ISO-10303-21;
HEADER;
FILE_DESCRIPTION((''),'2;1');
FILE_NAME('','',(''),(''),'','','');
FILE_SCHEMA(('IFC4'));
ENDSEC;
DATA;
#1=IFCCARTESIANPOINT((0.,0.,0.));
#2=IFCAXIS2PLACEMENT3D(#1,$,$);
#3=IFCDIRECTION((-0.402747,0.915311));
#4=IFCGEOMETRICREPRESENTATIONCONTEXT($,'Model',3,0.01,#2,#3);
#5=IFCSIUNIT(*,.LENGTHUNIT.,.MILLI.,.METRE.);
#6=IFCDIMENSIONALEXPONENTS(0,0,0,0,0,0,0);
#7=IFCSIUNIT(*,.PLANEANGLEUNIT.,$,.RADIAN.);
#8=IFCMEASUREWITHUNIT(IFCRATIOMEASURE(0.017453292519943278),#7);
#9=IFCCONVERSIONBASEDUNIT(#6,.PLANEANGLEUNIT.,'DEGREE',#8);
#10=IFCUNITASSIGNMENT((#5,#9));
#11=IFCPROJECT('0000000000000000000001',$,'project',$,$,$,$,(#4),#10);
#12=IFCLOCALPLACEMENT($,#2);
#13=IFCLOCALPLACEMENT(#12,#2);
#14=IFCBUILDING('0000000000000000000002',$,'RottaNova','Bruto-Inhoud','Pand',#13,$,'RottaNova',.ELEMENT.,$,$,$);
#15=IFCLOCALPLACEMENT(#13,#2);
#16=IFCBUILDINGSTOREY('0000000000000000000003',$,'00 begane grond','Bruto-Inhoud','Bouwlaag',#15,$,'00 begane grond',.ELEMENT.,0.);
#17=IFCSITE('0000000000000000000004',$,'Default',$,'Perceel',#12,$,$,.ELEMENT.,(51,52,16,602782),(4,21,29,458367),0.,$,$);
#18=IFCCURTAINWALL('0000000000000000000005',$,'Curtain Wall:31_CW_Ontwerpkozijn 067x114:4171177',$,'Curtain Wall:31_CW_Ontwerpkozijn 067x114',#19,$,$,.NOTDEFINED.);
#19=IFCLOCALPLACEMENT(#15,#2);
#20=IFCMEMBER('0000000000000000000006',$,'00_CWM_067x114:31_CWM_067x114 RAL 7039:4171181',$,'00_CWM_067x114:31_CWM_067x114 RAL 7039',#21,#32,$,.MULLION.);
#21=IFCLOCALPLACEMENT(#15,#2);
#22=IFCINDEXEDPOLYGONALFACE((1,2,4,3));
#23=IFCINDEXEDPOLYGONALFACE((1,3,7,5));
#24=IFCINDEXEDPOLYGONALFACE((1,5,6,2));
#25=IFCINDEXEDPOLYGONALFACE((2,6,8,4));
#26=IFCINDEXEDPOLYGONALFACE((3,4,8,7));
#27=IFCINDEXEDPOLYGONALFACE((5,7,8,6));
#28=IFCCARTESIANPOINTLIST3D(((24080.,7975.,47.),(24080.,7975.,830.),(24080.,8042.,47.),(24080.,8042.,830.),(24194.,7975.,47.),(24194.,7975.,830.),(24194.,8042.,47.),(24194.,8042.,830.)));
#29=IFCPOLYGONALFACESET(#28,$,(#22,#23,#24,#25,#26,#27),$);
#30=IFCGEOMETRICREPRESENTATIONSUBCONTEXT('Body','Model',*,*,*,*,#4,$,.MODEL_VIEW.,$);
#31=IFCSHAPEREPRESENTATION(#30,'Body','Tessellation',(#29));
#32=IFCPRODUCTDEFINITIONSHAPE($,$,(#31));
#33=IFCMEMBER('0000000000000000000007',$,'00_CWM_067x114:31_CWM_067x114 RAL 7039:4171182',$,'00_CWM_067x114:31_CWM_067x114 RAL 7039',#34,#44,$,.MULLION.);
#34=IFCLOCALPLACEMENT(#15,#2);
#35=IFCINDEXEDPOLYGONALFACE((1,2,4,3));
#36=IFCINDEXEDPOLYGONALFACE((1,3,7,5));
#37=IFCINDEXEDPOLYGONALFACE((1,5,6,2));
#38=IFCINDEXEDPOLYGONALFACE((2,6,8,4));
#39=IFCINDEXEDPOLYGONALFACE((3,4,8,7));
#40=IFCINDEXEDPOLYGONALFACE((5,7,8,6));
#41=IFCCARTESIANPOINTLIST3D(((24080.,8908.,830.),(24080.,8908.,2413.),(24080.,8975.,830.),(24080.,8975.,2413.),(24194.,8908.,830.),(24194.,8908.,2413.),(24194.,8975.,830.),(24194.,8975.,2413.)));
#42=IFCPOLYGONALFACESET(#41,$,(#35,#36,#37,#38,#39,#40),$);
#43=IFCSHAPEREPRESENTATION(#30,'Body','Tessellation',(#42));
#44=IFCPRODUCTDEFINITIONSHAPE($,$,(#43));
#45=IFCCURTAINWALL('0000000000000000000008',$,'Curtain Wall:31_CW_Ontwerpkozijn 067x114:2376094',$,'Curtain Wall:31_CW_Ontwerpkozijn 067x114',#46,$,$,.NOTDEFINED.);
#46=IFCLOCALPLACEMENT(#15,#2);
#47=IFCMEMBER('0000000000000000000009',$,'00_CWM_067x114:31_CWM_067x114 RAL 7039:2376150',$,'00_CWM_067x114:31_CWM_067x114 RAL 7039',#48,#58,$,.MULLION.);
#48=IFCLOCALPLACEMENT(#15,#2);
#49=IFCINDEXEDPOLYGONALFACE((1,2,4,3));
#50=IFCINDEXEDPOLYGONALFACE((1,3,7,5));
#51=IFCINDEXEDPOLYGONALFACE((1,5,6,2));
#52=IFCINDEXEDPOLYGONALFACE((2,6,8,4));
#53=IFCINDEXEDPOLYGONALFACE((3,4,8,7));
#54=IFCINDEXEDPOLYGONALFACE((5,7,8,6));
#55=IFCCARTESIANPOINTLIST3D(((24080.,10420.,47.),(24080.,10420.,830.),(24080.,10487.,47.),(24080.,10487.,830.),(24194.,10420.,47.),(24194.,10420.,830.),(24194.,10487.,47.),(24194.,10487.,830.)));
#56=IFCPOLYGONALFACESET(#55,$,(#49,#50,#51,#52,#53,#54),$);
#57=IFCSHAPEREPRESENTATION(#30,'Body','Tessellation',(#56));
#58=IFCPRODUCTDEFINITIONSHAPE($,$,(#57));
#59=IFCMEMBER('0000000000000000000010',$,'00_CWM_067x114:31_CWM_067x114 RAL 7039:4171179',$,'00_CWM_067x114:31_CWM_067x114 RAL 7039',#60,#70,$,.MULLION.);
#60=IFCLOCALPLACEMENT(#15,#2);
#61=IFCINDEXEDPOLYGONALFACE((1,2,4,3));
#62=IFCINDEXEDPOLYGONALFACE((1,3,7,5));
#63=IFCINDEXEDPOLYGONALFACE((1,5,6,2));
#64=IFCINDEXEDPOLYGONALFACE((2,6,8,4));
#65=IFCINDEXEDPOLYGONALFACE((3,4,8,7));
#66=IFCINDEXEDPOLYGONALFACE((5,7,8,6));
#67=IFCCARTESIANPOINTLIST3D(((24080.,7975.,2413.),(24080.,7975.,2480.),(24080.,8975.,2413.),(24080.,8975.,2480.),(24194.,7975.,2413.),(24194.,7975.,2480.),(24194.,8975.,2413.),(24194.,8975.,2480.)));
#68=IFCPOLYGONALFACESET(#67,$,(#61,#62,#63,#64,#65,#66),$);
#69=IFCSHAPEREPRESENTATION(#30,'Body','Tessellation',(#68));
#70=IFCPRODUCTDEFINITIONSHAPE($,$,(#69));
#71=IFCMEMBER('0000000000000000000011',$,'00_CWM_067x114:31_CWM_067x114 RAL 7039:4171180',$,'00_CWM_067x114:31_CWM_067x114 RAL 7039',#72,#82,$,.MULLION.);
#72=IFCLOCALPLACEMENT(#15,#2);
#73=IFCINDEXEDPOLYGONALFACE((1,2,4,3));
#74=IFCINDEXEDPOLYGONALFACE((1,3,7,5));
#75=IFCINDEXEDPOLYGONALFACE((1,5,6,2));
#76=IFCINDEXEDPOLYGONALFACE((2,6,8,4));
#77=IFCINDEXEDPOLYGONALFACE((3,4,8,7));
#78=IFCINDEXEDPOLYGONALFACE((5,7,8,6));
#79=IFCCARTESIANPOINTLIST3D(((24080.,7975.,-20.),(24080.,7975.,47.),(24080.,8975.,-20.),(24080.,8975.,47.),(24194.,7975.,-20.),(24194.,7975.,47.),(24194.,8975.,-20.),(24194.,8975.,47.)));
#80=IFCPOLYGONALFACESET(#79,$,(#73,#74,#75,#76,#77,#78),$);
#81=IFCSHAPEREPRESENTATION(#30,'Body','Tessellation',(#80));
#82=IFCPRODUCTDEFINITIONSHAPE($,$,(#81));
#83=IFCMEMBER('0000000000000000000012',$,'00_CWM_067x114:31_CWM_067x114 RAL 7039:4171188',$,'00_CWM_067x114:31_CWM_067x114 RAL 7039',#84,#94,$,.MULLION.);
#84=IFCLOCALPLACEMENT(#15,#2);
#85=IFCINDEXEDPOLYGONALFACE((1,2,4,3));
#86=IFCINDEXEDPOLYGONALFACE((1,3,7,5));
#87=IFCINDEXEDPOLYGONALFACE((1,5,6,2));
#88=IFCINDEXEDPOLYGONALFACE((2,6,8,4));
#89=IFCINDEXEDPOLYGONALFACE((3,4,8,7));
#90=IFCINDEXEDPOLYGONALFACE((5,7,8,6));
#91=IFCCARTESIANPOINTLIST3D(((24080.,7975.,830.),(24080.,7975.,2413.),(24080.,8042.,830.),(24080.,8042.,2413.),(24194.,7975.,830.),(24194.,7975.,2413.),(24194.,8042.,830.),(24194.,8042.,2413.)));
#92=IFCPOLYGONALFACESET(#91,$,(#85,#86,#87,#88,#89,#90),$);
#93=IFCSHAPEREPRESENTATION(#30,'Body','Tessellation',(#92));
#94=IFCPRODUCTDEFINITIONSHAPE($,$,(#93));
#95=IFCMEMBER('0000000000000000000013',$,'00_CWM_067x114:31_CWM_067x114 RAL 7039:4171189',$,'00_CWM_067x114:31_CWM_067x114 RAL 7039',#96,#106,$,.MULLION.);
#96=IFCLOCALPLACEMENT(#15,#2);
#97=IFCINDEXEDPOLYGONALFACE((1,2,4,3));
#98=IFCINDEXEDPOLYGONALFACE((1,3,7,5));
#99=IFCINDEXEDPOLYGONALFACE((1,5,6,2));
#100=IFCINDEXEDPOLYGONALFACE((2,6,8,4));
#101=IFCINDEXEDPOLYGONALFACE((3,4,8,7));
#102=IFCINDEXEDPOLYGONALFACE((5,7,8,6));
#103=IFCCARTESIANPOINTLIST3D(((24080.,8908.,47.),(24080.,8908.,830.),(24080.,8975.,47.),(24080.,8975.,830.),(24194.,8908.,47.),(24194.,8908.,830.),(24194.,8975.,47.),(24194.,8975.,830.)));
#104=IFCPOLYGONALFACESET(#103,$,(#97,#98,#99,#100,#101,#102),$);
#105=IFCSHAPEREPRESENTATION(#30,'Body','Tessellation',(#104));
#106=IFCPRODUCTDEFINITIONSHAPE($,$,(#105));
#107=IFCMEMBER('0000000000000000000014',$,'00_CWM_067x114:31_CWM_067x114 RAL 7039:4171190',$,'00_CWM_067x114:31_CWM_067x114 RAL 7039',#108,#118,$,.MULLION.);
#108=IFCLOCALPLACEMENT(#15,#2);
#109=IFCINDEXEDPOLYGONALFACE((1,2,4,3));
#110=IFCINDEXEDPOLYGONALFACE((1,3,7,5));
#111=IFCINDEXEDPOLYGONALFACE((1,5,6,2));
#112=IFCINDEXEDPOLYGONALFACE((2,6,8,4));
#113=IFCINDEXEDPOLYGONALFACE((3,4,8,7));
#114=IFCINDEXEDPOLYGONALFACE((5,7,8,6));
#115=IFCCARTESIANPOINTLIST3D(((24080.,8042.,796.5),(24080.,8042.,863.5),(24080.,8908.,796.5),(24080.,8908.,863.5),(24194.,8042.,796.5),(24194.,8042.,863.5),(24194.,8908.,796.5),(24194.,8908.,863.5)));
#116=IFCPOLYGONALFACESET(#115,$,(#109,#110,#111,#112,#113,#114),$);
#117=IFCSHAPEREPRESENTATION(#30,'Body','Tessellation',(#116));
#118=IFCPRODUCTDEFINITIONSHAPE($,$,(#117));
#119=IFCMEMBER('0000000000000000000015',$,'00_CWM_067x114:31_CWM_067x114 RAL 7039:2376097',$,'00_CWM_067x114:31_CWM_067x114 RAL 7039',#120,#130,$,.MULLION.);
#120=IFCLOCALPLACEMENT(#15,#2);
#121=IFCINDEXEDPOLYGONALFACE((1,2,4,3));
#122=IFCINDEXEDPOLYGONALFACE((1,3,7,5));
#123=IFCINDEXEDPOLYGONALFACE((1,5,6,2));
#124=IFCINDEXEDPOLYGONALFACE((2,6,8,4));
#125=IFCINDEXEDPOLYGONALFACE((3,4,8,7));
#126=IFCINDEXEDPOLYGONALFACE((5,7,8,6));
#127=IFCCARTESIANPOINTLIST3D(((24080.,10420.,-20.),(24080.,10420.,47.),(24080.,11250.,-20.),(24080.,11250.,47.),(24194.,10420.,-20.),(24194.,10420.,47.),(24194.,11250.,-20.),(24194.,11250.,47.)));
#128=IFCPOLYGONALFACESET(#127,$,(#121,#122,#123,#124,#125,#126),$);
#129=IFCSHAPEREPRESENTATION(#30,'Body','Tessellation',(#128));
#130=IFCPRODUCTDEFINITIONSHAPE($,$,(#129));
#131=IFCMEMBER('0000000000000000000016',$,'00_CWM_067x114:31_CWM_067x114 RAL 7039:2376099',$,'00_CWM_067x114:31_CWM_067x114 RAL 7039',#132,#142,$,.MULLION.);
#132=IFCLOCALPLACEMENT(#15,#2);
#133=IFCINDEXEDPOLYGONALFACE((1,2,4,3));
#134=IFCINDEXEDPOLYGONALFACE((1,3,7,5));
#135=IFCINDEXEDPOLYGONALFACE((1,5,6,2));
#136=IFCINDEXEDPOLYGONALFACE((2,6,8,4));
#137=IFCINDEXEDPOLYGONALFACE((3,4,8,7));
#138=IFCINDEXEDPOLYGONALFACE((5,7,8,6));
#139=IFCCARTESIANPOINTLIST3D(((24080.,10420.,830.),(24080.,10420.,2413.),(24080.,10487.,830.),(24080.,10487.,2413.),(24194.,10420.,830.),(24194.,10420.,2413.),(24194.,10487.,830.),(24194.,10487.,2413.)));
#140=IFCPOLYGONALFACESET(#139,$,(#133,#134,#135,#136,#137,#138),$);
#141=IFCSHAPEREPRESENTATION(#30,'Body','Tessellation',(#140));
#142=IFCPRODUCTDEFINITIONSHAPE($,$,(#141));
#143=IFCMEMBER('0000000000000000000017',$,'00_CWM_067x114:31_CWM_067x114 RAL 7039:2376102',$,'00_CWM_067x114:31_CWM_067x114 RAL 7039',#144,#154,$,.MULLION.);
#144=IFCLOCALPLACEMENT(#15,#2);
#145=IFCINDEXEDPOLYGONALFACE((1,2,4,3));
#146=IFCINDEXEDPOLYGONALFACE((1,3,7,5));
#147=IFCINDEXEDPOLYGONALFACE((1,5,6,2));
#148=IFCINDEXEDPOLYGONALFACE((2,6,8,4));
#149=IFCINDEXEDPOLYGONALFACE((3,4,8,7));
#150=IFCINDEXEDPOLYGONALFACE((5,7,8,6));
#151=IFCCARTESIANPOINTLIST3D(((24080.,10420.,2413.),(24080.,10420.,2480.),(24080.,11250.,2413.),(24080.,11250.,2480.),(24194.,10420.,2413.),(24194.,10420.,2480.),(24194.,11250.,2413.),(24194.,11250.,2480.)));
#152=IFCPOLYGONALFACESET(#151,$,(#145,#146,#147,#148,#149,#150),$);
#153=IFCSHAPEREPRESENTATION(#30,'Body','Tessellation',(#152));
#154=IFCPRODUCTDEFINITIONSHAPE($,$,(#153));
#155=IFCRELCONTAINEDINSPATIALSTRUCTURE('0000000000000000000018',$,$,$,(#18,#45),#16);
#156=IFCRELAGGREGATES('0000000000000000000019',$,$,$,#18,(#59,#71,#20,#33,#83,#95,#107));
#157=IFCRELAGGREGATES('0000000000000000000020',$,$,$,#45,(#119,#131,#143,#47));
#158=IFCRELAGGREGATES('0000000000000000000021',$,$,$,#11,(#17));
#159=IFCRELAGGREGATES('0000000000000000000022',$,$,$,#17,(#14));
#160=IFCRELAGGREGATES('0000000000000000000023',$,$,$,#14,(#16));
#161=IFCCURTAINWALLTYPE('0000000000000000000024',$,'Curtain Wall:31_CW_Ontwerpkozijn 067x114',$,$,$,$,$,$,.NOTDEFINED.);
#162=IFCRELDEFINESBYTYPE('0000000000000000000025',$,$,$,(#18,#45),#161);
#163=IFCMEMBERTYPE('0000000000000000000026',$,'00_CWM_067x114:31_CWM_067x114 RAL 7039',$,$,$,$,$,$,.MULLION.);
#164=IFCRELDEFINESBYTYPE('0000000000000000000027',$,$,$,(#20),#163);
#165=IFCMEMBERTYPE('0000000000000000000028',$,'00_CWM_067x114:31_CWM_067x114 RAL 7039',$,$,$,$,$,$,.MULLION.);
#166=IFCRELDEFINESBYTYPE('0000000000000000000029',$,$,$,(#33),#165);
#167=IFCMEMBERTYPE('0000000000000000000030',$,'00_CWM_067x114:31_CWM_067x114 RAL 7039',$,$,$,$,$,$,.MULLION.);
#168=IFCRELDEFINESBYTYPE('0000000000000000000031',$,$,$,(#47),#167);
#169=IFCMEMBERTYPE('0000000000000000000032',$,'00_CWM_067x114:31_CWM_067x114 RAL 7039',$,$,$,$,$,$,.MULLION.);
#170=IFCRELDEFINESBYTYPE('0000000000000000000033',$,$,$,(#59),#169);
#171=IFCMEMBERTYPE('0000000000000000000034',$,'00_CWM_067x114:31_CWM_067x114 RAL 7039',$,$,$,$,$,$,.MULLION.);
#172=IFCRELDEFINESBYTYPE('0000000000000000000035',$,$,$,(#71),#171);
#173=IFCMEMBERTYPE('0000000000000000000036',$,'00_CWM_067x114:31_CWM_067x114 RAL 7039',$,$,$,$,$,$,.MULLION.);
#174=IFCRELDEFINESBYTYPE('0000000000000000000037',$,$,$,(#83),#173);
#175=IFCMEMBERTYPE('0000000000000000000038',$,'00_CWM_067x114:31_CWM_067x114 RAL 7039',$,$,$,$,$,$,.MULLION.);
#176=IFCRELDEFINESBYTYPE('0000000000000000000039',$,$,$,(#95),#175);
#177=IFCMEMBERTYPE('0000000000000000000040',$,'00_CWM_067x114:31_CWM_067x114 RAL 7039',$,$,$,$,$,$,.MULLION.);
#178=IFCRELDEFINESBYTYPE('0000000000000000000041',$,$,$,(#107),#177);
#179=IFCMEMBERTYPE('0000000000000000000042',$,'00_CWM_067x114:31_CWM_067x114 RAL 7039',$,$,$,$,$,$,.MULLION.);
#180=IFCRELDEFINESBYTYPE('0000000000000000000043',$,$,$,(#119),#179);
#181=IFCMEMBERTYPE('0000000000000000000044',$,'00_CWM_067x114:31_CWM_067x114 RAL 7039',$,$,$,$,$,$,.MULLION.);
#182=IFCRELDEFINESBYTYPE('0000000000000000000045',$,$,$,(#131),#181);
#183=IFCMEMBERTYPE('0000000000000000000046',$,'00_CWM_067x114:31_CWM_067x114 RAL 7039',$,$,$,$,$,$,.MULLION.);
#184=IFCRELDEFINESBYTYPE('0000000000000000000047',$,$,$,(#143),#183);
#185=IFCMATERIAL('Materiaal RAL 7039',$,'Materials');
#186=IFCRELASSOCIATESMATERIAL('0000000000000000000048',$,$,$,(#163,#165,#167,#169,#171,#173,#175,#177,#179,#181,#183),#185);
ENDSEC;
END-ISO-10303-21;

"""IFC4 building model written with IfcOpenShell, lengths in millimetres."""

from ifc_helpers import new_model, entity, si_unit, converted_unit, direction, frame, frame_2d, origin, origin_2d_with_axis, place, context, subcontext, project, spatial, rectangle, extrude, source, transform, mapped, material, material_profile, profile_set, type_object, type_shapes, element, aggregate, save


model = new_model("IFC4")

# Units and contexts
model_context = context("Model", 3, precision=0.01, world=origin(), true_north=direction((-0.402747, 0.915311)))
body_context = subcontext(model_context, "Body", "Model", "MODEL_VIEW")
ifc_project = project(units=[si_unit("LENGTHUNIT", "METRE", prefix="MILLI"), converted_unit("PLANEANGLEUNIT", "DEGREE", entity("IfcRatioMeasure", 0.017453292519943278), si_unit("PLANEANGLEUNIT", "RADIAN"), dimensions=[0, 0, 0, 0, 0, 0, 0])], contexts=[model_context])

# Site, building, storey
site_placement = place(None, origin())
site = spatial("IfcSite", under=ifc_project, at=site_placement, Name="Default", ObjectType="Perceel", CompositionType="ELEMENT", RefLatitude=(51, 52, 16, 602782), RefLongitude=(4, 21, 29, 458367), RefElevation=0.0)
building_placement = place(site_placement, origin())
building = spatial("IfcBuilding", under=site, at=building_placement, Name="RottaNova", Description="Bruto-Inhoud", ObjectType="Pand", LongName="RottaNova", CompositionType="ELEMENT")
storey_placement = place(building_placement, origin())
storey = spatial("IfcBuildingStorey", under=building, at=storey_placement, Name="00 begane grond", Description="Bruto-Inhoud", ObjectType="Bouwlaag", LongName="00 begane grond", CompositionType="ELEMENT", Elevation=0.0)

# Curtain wall, members
curtain_wall_type = type_object("IfcCurtainWallType", Name="Curtain Wall:31_CW_Ontwerpkozijn 067x114", PredefinedType="NOTDEFINED")
curtain_wall_1_placement = place(storey_placement, origin())
curtain_wall_1 = element("IfcCurtainWall", 1, at=curtain_wall_1_placement, inside=storey, type_object=curtain_wall_type, Name="Curtain Wall:31_CW_Ontwerpkozijn 067x114:4171177", ObjectType="Curtain Wall:31_CW_Ontwerpkozijn 067x114", PredefinedType="NOTDEFINED")
ifc_material_1 = material(Name="Materiaal RAL 7039", Category="Materials")
ifc_material_profile = material_profile(ifc_material_1, rectangle(XDim=114.0, YDim=67.0, at=origin_2d_with_axis()), Name="31_CWM_067x114 RAL 7039")
ifc_profile_set = profile_set([ifc_material_profile], Name="31_CWM_067x114 RAL 7039")
member_type_1 = type_object("IfcMemberType", Name="00_CWM_067x114:31_CWM_067x114 RAL 7039", PredefinedType="MULLION", material=ifc_profile_set)
shared_shape_1 = source(origin(), body_context, "Body", "SweptSolid", [
    extrude(rectangle(XDim=114.0, YDim=67.0, at=frame_2d((0.0, 0.0), x_axis=(1.0, 0.0))), frame((-33.5, -57.0, -783.0), z_axis=(0.0, 0.0, 1.0), x_axis=(0.0, -1.0, 0.0)), (0.0, 0.0, 1.0), 783.0),
])
type_shapes(member_type_1, [shared_shape_1])
member_1_placement = place(curtain_wall_1_placement, frame((24080.0, 7975.0, 47.0), z_axis=(0.0, 0.0, -1.0), x_axis=(0.0, -1.0, 0.0)))
member_1 = element("IfcMember", 2, at=member_1_placement, type_object=member_type_1, Name="00_CWM_067x114:31_CWM_067x114 RAL 7039:4171181", ObjectType="00_CWM_067x114:31_CWM_067x114 RAL 7039", PredefinedType="MULLION", context=body_context, shape_type="MappedRepresentation", body=[
    mapped(shared_shape_1, transform((0.0, 0.0, 0.0), scale=1.0)),
])
member_type_2 = type_object("IfcMemberType", Name="00_CWM_067x114:31_CWM_067x114 RAL 7039", PredefinedType="MULLION", material=ifc_profile_set)
shared_shape_2 = source(origin(), body_context, "Body", "SweptSolid", [
    extrude(rectangle(XDim=114.0, YDim=67.0, at=frame_2d((0.0, 0.0), x_axis=(1.0, 0.0))), frame((-33.5, -57.0, -1583.0), z_axis=(0.0, 0.0, 1.0), x_axis=(0.0, -1.0, 0.0)), (0.0, 0.0, 1.0), 1583.0),
])
type_shapes(member_type_2, [shared_shape_2])
member_2_placement = place(curtain_wall_1_placement, frame((24080.0, 8975.0, 2413.0), z_axis=(0.0, 0.0, 1.0), x_axis=(0.0, 1.0, 0.0)))
member_2 = element("IfcMember", 3, at=member_2_placement, type_object=member_type_2, Name="00_CWM_067x114:31_CWM_067x114 RAL 7039:4171182", ObjectType="00_CWM_067x114:31_CWM_067x114 RAL 7039", PredefinedType="MULLION", context=body_context, shape_type="MappedRepresentation", body=[
    mapped(shared_shape_2, transform((0.0, 0.0, 0.0), scale=1.0)),
])

# Curtain wall, member
curtain_wall_2_placement = place(storey_placement, origin())
curtain_wall_2 = element("IfcCurtainWall", 4, at=curtain_wall_2_placement, inside=storey, type_object=curtain_wall_type, Name="Curtain Wall:31_CW_Ontwerpkozijn 067x114:2376094", ObjectType="Curtain Wall:31_CW_Ontwerpkozijn 067x114", PredefinedType="NOTDEFINED")
member_type_3 = type_object("IfcMemberType", Name="00_CWM_067x114:31_CWM_067x114 RAL 7039", PredefinedType="MULLION", material=ifc_profile_set)
shared_shape_3 = source(origin(), body_context, "Body", "SweptSolid", [
    extrude(rectangle(XDim=114.0, YDim=67.0, at=origin_2d_with_axis()), frame((-33.5, 57.0, -783.0), z_axis=(0.0, 0.0, 1.0), x_axis=(0.0, -1.0, 0.0)), (0.0, 0.0, 1.0), 783.0),
])
type_shapes(member_type_3, [shared_shape_3])
member_3_placement = place(curtain_wall_2_placement, frame((24080.0, 10420.0, 830.0), z_axis=(0.0, 0.0, 1.0), x_axis=(0.0, -1.0, 0.0)))
member_3 = element("IfcMember", 5, at=member_3_placement, type_object=member_type_3, Name="00_CWM_067x114:31_CWM_067x114 RAL 7039:2376150", ObjectType="00_CWM_067x114:31_CWM_067x114 RAL 7039", PredefinedType="MULLION", context=body_context, shape_type="MappedRepresentation", body=[
    mapped(shared_shape_3, transform((0.0, 0.0, 0.0), scale=1.0)),
])

# Members
member_type_4 = type_object("IfcMemberType", Name="00_CWM_067x114:31_CWM_067x114 RAL 7039", PredefinedType="MULLION", material=ifc_profile_set)
shared_shape_4 = source(origin(), body_context, "Body", "SweptSolid", [
    extrude(rectangle(XDim=114.0, YDim=67.0, at=frame_2d((0.0, 0.0), x_axis=(1.0, 0.0))), frame((-33.5, -57.0, -1000.0), z_axis=(0.0, 0.0, 1.0), x_axis=(0.0, -1.0, 0.0)), (0.0, 0.0, 1.0), 1000.0),
])
type_shapes(member_type_4, [shared_shape_4])
member_4_placement = place(curtain_wall_1_placement, frame((24080.0, 7975.0, 2480.0), z_axis=(0.0, -1.0, 0.0), x_axis=(0.0, 0.0, 1.0)))
member_4 = element("IfcMember", 6, at=member_4_placement, type_object=member_type_4, Name="00_CWM_067x114:31_CWM_067x114 RAL 7039:4171179", ObjectType="00_CWM_067x114:31_CWM_067x114 RAL 7039", PredefinedType="MULLION", context=body_context, shape_type="MappedRepresentation", body=[
    mapped(shared_shape_4, transform((0.0, 0.0, 0.0), scale=1.0)),
])
member_type_5 = type_object("IfcMemberType", Name="00_CWM_067x114:31_CWM_067x114 RAL 7039", PredefinedType="MULLION", material=ifc_profile_set)
shared_shape_5 = source(origin(), body_context, "Body", "SweptSolid", [
    extrude(rectangle(XDim=114.0, YDim=67.0, at=frame_2d((0.0, 0.0), x_axis=(1.0, 0.0))), frame((-33.5, -57.0, -1000.0), z_axis=(0.0, 0.0, 1.0), x_axis=(0.0, -1.0, 0.0)), (0.0, 0.0, 1.0), 1000.0),
])
type_shapes(member_type_5, [shared_shape_5])
member_5_placement = place(curtain_wall_1_placement, frame((24080.0, 8975.0, -20.0), z_axis=(0.0, 1.0, 0.0), x_axis=(0.0, 0.0, -1.0)))
member_5 = element("IfcMember", 7, at=member_5_placement, type_object=member_type_5, Name="00_CWM_067x114:31_CWM_067x114 RAL 7039:4171180", ObjectType="00_CWM_067x114:31_CWM_067x114 RAL 7039", PredefinedType="MULLION", context=body_context, shape_type="MappedRepresentation", body=[
    mapped(shared_shape_5, transform((0.0, 0.0, 0.0), scale=1.0)),
])
member_type_6 = type_object("IfcMemberType", Name="00_CWM_067x114:31_CWM_067x114 RAL 7039", PredefinedType="MULLION", material=ifc_profile_set)
shared_shape_6 = source(origin(), body_context, "Body", "SweptSolid", [
    extrude(rectangle(XDim=114.0, YDim=67.0, at=frame_2d((0.0, 0.0), x_axis=(1.0, 0.0))), frame((-33.5, -57.0, -1583.0), z_axis=(0.0, 0.0, 1.0), x_axis=(0.0, -1.0, 0.0)), (0.0, 0.0, 1.0), 1583.0),
])
type_shapes(member_type_6, [shared_shape_6])
member_6_placement = place(curtain_wall_1_placement, frame((24080.0, 7975.0, 830.0), z_axis=(0.0, 0.0, -1.0), x_axis=(0.0, -1.0, 0.0)))
member_6 = element("IfcMember", 8, at=member_6_placement, type_object=member_type_6, Name="00_CWM_067x114:31_CWM_067x114 RAL 7039:4171188", ObjectType="00_CWM_067x114:31_CWM_067x114 RAL 7039", PredefinedType="MULLION", context=body_context, shape_type="MappedRepresentation", body=[
    mapped(shared_shape_6, transform((0.0, 0.0, 0.0), scale=1.0)),
])
member_type_7 = type_object("IfcMemberType", Name="00_CWM_067x114:31_CWM_067x114 RAL 7039", PredefinedType="MULLION", material=ifc_profile_set)
shared_shape_7 = source(origin(), body_context, "Body", "SweptSolid", [
    extrude(rectangle(XDim=114.0, YDim=67.0, at=frame_2d((0.0, 0.0), x_axis=(1.0, 0.0))), frame((-33.5, -57.0, -783.0), z_axis=(0.0, 0.0, 1.0), x_axis=(0.0, -1.0, 0.0)), (0.0, 0.0, 1.0), 783.0),
])
type_shapes(member_type_7, [shared_shape_7])
member_7_placement = place(curtain_wall_1_placement, frame((24080.0, 8975.0, 830.0), z_axis=(0.0, 0.0, 1.0), x_axis=(0.0, 1.0, 0.0)))
member_7 = element("IfcMember", 9, at=member_7_placement, type_object=member_type_7, Name="00_CWM_067x114:31_CWM_067x114 RAL 7039:4171189", ObjectType="00_CWM_067x114:31_CWM_067x114 RAL 7039", PredefinedType="MULLION", context=body_context, shape_type="MappedRepresentation", body=[
    mapped(shared_shape_7, transform((0.0, 0.0, 0.0), scale=1.0)),
])
member_type_8 = type_object("IfcMemberType", Name="00_CWM_067x114:31_CWM_067x114 RAL 7039", PredefinedType="MULLION", material=ifc_profile_set)
shared_shape_8 = source(origin(), body_context, "Body", "SweptSolid", [
    extrude(rectangle(XDim=114.0, YDim=67.0, at=origin_2d_with_axis()), frame((0.0, -57.0, -866.0), z_axis=(0.0, 0.0, 1.0), x_axis=(0.0, -1.0, 0.0)), (0.0, 0.0, 1.0), 866.0),
])
type_shapes(member_type_8, [shared_shape_8])
member_8_placement = place(curtain_wall_1_placement, frame((24080.0, 8042.0, 830.0), z_axis=(0.0, -1.0, 0.0), x_axis=(0.0, 0.0, 1.0)))
member_8 = element("IfcMember", 10, at=member_8_placement, type_object=member_type_8, Name="00_CWM_067x114:31_CWM_067x114 RAL 7039:4171190", ObjectType="00_CWM_067x114:31_CWM_067x114 RAL 7039", PredefinedType="MULLION", context=body_context, shape_type="MappedRepresentation", body=[
    mapped(shared_shape_8, transform((0.0, 0.0, 0.0), scale=1.0)),
])
member_type_9 = type_object("IfcMemberType", Name="00_CWM_067x114:31_CWM_067x114 RAL 7039", PredefinedType="MULLION", material=ifc_profile_set)
shared_shape_9 = source(origin(), body_context, "Body", "SweptSolid", [
    extrude(rectangle(XDim=114.0, YDim=67.0, at=origin_2d_with_axis()), frame((-33.5, 57.0, -830.0), z_axis=(0.0, 0.0, 1.0), x_axis=(0.0, -1.0, 0.0)), (0.0, 0.0, 1.0), 830.0),
])
type_shapes(member_type_9, [shared_shape_9])
member_9_placement = place(curtain_wall_2_placement, frame((24080.0, 10420.0, -20.0), z_axis=(0.0, -1.0, 0.0), x_axis=(0.0, 0.0, -1.0)))
member_9 = element("IfcMember", 11, at=member_9_placement, type_object=member_type_9, Name="00_CWM_067x114:31_CWM_067x114 RAL 7039:2376097", ObjectType="00_CWM_067x114:31_CWM_067x114 RAL 7039", PredefinedType="MULLION", context=body_context, shape_type="MappedRepresentation", body=[
    mapped(shared_shape_9, transform((0.0, 0.0, 0.0), scale=1.0)),
])
member_type_10 = type_object("IfcMemberType", Name="00_CWM_067x114:31_CWM_067x114 RAL 7039", PredefinedType="MULLION", material=ifc_profile_set)
shared_shape_10 = source(origin(), body_context, "Body", "SweptSolid", [
    extrude(rectangle(XDim=114.0, YDim=67.0, at=origin_2d_with_axis()), frame((-33.5, 57.0, -1583.0), z_axis=(0.0, 0.0, 1.0), x_axis=(0.0, -1.0, 0.0)), (0.0, 0.0, 1.0), 1583.0),
])
type_shapes(member_type_10, [shared_shape_10])
member_10_placement = place(curtain_wall_2_placement, frame((24080.0, 10420.0, 2413.0), z_axis=(0.0, 0.0, 1.0), x_axis=(0.0, -1.0, 0.0)))
member_10 = element("IfcMember", 12, at=member_10_placement, type_object=member_type_10, Name="00_CWM_067x114:31_CWM_067x114 RAL 7039:2376099", ObjectType="00_CWM_067x114:31_CWM_067x114 RAL 7039", PredefinedType="MULLION", context=body_context, shape_type="MappedRepresentation", body=[
    mapped(shared_shape_10, transform((0.0, 0.0, 0.0), scale=1.0)),
])
member_type_11 = type_object("IfcMemberType", Name="00_CWM_067x114:31_CWM_067x114 RAL 7039", PredefinedType="MULLION", material=ifc_profile_set)
shared_shape_11 = source(origin(), body_context, "Body", "SweptSolid", [
    extrude(rectangle(XDim=114.0, YDim=67.0, at=origin_2d_with_axis()), frame((-33.5, 57.0, -830.0), z_axis=(0.0, 0.0, 1.0), x_axis=(0.0, -1.0, 0.0)), (0.0, 0.0, 1.0), 830.0),
])
type_shapes(member_type_11, [shared_shape_11])
member_11_placement = place(curtain_wall_2_placement, frame((24080.0, 11250.0, 2480.0), z_axis=(0.0, 1.0, 0.0), x_axis=(0.0, 0.0, 1.0)))
member_11 = element("IfcMember", 13, at=member_11_placement, type_object=member_type_11, Name="00_CWM_067x114:31_CWM_067x114 RAL 7039:2376102", ObjectType="00_CWM_067x114:31_CWM_067x114 RAL 7039", PredefinedType="MULLION", context=body_context, shape_type="MappedRepresentation", body=[
    mapped(shared_shape_11, transform((0.0, 0.0, 0.0), scale=1.0)),
])

aggregate(curtain_wall_1, [member_4, member_5, member_1, member_2, member_6, member_7, member_8])
aggregate(curtain_wall_2, [member_9, member_10, member_11, member_3])

save(model, "model.ifc")
